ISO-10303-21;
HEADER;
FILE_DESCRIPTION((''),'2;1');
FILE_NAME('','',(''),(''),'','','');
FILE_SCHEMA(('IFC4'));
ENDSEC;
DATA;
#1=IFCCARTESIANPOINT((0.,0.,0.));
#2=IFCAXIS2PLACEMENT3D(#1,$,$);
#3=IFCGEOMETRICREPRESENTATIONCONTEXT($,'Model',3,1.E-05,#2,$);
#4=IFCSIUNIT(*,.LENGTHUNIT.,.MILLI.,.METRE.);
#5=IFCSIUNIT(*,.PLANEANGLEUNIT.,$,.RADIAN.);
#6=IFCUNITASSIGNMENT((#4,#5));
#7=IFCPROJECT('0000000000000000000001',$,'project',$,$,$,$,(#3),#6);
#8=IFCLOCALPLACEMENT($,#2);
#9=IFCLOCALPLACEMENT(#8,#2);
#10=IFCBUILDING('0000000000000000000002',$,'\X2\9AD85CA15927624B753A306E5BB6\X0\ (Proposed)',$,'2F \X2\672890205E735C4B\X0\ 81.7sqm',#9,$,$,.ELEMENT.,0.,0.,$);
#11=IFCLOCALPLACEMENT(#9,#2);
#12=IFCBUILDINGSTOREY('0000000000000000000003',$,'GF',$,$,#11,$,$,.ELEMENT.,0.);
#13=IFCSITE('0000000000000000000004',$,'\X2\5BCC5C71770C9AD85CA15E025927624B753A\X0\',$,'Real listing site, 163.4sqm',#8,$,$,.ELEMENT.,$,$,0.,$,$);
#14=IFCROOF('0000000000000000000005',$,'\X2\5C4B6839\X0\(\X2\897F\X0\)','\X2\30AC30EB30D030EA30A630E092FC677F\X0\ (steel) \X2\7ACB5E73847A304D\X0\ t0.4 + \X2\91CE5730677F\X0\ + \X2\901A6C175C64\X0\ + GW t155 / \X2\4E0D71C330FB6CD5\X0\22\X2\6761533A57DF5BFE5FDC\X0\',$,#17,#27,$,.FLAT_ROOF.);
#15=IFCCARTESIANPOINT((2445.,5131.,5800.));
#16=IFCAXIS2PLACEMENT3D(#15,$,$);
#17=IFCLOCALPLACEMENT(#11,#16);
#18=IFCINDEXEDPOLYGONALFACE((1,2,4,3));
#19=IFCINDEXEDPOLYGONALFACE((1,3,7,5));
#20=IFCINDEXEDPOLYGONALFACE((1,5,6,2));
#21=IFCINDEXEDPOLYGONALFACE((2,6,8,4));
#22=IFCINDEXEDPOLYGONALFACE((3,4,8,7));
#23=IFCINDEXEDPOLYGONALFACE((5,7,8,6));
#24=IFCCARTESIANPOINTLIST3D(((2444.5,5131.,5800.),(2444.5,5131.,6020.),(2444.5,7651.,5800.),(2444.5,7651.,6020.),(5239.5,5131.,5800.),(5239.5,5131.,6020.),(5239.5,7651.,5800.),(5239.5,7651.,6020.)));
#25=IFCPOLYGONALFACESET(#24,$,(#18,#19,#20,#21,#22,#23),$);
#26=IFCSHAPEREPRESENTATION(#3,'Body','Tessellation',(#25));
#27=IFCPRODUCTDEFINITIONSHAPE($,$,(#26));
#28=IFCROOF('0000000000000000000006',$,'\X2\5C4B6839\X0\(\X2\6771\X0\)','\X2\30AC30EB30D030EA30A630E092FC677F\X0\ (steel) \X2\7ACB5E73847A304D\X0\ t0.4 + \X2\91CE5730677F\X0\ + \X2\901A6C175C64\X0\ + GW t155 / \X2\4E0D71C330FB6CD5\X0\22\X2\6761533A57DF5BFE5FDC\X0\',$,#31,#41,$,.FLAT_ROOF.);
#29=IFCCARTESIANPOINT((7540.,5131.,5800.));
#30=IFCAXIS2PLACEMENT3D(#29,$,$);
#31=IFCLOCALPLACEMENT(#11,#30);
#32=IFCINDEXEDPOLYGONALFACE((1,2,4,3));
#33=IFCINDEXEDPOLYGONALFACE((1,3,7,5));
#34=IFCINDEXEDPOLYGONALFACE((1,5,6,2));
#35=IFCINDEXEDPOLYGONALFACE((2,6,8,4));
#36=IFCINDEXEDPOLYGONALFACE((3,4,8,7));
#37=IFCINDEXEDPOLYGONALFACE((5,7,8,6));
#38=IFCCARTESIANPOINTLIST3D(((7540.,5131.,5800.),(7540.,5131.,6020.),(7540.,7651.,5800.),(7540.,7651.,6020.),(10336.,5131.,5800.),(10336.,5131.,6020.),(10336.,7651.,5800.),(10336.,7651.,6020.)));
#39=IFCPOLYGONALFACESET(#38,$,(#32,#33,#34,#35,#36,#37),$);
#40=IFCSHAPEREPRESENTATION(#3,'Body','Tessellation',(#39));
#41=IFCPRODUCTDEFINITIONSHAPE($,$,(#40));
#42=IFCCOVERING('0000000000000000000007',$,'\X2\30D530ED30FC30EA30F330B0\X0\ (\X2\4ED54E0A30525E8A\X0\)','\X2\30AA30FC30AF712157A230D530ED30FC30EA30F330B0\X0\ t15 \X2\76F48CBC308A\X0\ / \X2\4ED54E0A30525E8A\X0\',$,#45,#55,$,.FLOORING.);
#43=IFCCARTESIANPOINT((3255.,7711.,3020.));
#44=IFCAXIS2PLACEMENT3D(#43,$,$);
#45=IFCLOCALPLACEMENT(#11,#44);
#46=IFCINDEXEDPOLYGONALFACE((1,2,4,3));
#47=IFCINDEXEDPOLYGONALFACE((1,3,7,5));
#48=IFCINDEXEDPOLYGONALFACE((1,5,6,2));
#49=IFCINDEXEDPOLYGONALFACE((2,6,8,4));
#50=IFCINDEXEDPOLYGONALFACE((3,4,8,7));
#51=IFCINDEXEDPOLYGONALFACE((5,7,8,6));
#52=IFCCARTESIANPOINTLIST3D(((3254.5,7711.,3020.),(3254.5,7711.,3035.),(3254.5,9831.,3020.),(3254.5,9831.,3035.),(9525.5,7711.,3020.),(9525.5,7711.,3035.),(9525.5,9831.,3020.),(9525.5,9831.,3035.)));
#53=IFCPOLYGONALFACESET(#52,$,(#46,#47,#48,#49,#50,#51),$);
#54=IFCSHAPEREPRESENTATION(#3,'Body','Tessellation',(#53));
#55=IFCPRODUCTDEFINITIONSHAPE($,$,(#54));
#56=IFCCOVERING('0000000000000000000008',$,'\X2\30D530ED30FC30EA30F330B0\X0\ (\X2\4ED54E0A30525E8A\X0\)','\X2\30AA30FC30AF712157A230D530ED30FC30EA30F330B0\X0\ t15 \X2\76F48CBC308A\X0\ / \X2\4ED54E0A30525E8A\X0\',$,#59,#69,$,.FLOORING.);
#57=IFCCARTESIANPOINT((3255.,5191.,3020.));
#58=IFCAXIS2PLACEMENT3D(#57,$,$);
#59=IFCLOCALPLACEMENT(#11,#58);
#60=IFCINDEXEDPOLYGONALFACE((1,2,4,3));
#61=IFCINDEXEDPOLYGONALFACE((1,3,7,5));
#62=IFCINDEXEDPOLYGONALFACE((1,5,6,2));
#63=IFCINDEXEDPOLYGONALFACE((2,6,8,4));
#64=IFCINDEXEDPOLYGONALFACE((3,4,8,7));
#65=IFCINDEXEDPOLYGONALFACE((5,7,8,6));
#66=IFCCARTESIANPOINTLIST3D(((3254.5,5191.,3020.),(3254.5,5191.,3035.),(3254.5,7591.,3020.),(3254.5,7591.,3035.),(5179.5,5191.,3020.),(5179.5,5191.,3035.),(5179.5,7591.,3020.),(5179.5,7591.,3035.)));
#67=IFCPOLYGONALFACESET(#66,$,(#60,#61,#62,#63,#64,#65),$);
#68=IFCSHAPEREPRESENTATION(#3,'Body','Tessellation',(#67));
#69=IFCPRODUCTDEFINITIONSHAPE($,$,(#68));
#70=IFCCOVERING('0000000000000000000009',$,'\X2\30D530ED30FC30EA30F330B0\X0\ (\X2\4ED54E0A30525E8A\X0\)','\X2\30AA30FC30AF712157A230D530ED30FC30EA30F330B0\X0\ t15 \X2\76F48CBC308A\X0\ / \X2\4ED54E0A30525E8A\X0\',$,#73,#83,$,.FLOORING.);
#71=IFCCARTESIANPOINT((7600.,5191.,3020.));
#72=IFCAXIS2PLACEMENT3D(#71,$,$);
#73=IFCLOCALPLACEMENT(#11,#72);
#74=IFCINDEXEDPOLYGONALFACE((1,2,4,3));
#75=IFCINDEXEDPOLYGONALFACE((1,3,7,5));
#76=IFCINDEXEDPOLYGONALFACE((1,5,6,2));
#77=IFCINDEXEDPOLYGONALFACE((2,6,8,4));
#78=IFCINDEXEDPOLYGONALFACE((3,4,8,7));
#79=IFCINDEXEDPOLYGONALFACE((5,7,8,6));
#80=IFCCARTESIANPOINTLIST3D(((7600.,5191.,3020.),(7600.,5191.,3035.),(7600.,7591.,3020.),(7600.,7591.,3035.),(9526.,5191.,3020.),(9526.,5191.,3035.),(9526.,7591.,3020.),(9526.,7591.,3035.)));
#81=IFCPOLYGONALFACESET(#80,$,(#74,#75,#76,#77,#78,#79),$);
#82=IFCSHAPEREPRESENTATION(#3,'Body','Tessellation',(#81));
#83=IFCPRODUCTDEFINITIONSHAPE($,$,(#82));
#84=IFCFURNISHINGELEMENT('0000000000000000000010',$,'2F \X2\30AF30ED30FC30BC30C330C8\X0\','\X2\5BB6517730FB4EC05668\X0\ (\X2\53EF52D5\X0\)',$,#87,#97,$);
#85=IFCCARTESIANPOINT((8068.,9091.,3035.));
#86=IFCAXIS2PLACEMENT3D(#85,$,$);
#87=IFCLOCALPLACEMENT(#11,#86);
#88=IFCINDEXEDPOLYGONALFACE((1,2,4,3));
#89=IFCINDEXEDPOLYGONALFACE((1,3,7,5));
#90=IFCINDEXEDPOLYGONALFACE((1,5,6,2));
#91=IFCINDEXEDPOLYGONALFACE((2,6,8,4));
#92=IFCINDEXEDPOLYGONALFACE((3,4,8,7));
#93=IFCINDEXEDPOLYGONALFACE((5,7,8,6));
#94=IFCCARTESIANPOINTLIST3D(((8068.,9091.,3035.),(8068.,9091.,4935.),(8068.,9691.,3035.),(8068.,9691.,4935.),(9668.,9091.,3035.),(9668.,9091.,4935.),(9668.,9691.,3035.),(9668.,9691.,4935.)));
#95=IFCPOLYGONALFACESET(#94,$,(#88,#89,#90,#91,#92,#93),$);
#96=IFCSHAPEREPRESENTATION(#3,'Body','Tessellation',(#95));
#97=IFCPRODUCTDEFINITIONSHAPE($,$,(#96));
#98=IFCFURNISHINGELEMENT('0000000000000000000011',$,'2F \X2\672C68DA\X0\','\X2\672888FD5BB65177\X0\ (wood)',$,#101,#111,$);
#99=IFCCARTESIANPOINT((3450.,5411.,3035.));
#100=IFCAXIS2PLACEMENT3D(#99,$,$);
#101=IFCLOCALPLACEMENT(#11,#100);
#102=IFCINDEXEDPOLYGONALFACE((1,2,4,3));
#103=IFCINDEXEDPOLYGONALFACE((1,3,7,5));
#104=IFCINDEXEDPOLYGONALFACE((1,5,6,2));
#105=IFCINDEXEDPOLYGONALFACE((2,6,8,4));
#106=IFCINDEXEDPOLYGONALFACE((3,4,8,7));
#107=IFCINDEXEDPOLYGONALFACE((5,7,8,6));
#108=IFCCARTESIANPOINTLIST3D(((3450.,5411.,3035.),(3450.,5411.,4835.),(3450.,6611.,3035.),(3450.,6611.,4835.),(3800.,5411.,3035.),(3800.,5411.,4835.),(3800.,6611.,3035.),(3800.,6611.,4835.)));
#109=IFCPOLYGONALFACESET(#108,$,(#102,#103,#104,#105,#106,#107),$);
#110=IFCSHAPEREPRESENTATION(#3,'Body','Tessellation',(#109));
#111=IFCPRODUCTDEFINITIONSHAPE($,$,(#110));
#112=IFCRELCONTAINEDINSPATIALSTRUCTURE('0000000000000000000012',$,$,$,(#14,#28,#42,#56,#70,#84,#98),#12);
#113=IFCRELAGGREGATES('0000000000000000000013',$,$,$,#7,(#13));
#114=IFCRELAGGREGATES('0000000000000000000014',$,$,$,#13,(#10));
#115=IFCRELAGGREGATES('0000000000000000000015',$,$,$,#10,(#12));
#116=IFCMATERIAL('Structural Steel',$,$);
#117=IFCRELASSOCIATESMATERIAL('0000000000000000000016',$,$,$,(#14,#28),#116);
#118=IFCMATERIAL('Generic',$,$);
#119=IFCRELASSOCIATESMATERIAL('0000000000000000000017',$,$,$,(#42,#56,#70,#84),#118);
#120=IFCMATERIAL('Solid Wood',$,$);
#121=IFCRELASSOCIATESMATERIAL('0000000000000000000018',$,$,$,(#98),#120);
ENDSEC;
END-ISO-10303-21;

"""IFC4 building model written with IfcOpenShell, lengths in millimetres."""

from ifc_helpers import new_model, si_unit, frame, frame_2d, origin, place, context, project, spatial, rectangle, extrude, material, element, save


model = new_model("IFC4")

# Units and contexts
model_context = context("Model", 3, precision=1e-05, world=origin())
ifc_project = project(units=[si_unit("LENGTHUNIT", "METRE", prefix="MILLI"), si_unit("PLANEANGLEUNIT", "RADIAN")], contexts=[model_context])

# Site, building, storey
site_placement = place(None, origin())
site = spatial("IfcSite", under=ifc_project, at=site_placement, Name="富山県高岡市大手町", ObjectType="Real listing site, 163.4sqm", CompositionType="ELEMENT", RefElevation=0.0)
building_placement = place(site_placement, origin())
building = spatial("IfcBuilding", under=site, at=building_placement, Name="高岡大手町の家 (Proposed)", ObjectType="2F 木造平屋 81.7sqm", CompositionType="ELEMENT", ElevationOfRefHeight=0.0, ElevationOfTerrain=0.0)
storey_placement = place(building_placement, origin())
storey = spatial("IfcBuildingStorey", under=building, at=storey_placement, Name="GF", CompositionType="ELEMENT", Elevation=0.0)

# Shared definitions
ifc_material_1 = material(Name="Solid Wood")

# Roofs
ifc_material_2 = material(Name="Structural Steel")
roof_1_placement = place(storey_placement, frame((2445.0, 5131.0, 5800.0)))
element("IfcRoof", 1, at=roof_1_placement, inside=storey, material=ifc_material_2, Name="屋根(西)", Description="ガルバリウム鋼板 (steel) 立平葺き t0.4 + 野地板 + 通気層 + GW t155 / 不燃・法22条区域対応", PredefinedType="FLAT_ROOF", context=model_context, shape_type="SweptSolid", body=[
    extrude(rectangle(XDim=2795.0, YDim=2520.0, at=frame_2d((1397.0, 1260.0))), frame((2445.0, 5131.0, 5800.0)), (0.0, 0.0, 1.0), 220.0),
])
roof_2_placement = place(storey_placement, frame((7540.0, 5131.0, 5800.0)))
element("IfcRoof", 2, at=roof_2_placement, inside=storey, material=ifc_material_2, Name="屋根(東)", Description="ガルバリウム鋼板 (steel) 立平葺き t0.4 + 野地板 + 通気層 + GW t155 / 不燃・法22条区域対応", PredefinedType="FLAT_ROOF", context=model_context, shape_type="SweptSolid", body=[
    extrude(rectangle(XDim=2796.0, YDim=2520.0, at=frame_2d((1398.0, 1260.0))), frame((7540.0, 5131.0, 5800.0)), (0.0, 0.0, 1.0), 220.0),
])

# Coverings
ifc_material_3 = material(Name="Generic")
covering_1_placement = place(storey_placement, frame((3255.0, 7711.0, 3020.0)))
element("IfcCovering", 3, at=covering_1_placement, inside=storey, material=ifc_material_3, Name="フローリング (仕上げ床)", Description="オーク無垢フローリング t15 直貼り / 仕上げ床", PredefinedType="FLOORING", context=model_context, shape_type="SweptSolid", body=[
    extrude(rectangle(XDim=6271.0, YDim=2120.0, at=frame_2d((3135.0, 1060.0))), frame((3255.0, 7711.0, 3020.0)), (0.0, 0.0, 1.0), 15.0),
])
covering_2_placement = place(storey_placement, frame((3255.0, 5191.0, 3020.0)))
element("IfcCovering", 4, at=covering_2_placement, inside=storey, material=ifc_material_3, Name="フローリング (仕上げ床)", Description="オーク無垢フローリング t15 直貼り / 仕上げ床", PredefinedType="FLOORING", context=model_context, shape_type="SweptSolid", body=[
    extrude(rectangle(XDim=1925.0, YDim=2400.0, at=frame_2d((962.0, 1200.0))), frame((3255.0, 5191.0, 3020.0)), (0.0, 0.0, 1.0), 15.0),
])
covering_3_placement = place(storey_placement, frame((7600.0, 5191.0, 3020.0)))
element("IfcCovering", 5, at=covering_3_placement, inside=storey, material=ifc_material_3, Name="フローリング (仕上げ床)", Description="オーク無垢フローリング t15 直貼り / 仕上げ床", PredefinedType="FLOORING", context=model_context, shape_type="SweptSolid", body=[
    extrude(rectangle(XDim=1926.0, YDim=2400.0, at=frame_2d((963.0, 1200.0))), frame((7600.0, 5191.0, 3020.0)), (0.0, 0.0, 1.0), 15.0),
])

# Furnishing elements
furnishing_1_placement = place(storey_placement, frame((8068.0, 9091.0, 3035.0)))
element("IfcFurnishingElement", 6, at=furnishing_1_placement, inside=storey, material=ifc_material_3, Name="2F クローゼット", Description="家具・什器 (可動)", context=model_context, shape_type="SweptSolid", body=[
    extrude(rectangle(XDim=1600.0, YDim=600.0, at=frame_2d((800.0, 300.0))), frame((8068.0, 9091.0, 3035.0)), (0.0, 0.0, 1.0), 1900.0),
])
furnishing_2_placement = place(storey_placement, frame((3450.0, 5411.0, 3035.0)))
element("IfcFurnishingElement", 7, at=furnishing_2_placement, inside=storey, material=ifc_material_1, Name="2F 本棚", Description="木製家具 (wood)", context=model_context, shape_type="SweptSolid", body=[
    extrude(rectangle(XDim=350.0, YDim=1200.0, at=frame_2d((175.0, 600.0))), frame((3450.0, 5411.0, 3035.0)), (0.0, 0.0, 1.0), 1800.0),
])

save(model, "model.ifc")
